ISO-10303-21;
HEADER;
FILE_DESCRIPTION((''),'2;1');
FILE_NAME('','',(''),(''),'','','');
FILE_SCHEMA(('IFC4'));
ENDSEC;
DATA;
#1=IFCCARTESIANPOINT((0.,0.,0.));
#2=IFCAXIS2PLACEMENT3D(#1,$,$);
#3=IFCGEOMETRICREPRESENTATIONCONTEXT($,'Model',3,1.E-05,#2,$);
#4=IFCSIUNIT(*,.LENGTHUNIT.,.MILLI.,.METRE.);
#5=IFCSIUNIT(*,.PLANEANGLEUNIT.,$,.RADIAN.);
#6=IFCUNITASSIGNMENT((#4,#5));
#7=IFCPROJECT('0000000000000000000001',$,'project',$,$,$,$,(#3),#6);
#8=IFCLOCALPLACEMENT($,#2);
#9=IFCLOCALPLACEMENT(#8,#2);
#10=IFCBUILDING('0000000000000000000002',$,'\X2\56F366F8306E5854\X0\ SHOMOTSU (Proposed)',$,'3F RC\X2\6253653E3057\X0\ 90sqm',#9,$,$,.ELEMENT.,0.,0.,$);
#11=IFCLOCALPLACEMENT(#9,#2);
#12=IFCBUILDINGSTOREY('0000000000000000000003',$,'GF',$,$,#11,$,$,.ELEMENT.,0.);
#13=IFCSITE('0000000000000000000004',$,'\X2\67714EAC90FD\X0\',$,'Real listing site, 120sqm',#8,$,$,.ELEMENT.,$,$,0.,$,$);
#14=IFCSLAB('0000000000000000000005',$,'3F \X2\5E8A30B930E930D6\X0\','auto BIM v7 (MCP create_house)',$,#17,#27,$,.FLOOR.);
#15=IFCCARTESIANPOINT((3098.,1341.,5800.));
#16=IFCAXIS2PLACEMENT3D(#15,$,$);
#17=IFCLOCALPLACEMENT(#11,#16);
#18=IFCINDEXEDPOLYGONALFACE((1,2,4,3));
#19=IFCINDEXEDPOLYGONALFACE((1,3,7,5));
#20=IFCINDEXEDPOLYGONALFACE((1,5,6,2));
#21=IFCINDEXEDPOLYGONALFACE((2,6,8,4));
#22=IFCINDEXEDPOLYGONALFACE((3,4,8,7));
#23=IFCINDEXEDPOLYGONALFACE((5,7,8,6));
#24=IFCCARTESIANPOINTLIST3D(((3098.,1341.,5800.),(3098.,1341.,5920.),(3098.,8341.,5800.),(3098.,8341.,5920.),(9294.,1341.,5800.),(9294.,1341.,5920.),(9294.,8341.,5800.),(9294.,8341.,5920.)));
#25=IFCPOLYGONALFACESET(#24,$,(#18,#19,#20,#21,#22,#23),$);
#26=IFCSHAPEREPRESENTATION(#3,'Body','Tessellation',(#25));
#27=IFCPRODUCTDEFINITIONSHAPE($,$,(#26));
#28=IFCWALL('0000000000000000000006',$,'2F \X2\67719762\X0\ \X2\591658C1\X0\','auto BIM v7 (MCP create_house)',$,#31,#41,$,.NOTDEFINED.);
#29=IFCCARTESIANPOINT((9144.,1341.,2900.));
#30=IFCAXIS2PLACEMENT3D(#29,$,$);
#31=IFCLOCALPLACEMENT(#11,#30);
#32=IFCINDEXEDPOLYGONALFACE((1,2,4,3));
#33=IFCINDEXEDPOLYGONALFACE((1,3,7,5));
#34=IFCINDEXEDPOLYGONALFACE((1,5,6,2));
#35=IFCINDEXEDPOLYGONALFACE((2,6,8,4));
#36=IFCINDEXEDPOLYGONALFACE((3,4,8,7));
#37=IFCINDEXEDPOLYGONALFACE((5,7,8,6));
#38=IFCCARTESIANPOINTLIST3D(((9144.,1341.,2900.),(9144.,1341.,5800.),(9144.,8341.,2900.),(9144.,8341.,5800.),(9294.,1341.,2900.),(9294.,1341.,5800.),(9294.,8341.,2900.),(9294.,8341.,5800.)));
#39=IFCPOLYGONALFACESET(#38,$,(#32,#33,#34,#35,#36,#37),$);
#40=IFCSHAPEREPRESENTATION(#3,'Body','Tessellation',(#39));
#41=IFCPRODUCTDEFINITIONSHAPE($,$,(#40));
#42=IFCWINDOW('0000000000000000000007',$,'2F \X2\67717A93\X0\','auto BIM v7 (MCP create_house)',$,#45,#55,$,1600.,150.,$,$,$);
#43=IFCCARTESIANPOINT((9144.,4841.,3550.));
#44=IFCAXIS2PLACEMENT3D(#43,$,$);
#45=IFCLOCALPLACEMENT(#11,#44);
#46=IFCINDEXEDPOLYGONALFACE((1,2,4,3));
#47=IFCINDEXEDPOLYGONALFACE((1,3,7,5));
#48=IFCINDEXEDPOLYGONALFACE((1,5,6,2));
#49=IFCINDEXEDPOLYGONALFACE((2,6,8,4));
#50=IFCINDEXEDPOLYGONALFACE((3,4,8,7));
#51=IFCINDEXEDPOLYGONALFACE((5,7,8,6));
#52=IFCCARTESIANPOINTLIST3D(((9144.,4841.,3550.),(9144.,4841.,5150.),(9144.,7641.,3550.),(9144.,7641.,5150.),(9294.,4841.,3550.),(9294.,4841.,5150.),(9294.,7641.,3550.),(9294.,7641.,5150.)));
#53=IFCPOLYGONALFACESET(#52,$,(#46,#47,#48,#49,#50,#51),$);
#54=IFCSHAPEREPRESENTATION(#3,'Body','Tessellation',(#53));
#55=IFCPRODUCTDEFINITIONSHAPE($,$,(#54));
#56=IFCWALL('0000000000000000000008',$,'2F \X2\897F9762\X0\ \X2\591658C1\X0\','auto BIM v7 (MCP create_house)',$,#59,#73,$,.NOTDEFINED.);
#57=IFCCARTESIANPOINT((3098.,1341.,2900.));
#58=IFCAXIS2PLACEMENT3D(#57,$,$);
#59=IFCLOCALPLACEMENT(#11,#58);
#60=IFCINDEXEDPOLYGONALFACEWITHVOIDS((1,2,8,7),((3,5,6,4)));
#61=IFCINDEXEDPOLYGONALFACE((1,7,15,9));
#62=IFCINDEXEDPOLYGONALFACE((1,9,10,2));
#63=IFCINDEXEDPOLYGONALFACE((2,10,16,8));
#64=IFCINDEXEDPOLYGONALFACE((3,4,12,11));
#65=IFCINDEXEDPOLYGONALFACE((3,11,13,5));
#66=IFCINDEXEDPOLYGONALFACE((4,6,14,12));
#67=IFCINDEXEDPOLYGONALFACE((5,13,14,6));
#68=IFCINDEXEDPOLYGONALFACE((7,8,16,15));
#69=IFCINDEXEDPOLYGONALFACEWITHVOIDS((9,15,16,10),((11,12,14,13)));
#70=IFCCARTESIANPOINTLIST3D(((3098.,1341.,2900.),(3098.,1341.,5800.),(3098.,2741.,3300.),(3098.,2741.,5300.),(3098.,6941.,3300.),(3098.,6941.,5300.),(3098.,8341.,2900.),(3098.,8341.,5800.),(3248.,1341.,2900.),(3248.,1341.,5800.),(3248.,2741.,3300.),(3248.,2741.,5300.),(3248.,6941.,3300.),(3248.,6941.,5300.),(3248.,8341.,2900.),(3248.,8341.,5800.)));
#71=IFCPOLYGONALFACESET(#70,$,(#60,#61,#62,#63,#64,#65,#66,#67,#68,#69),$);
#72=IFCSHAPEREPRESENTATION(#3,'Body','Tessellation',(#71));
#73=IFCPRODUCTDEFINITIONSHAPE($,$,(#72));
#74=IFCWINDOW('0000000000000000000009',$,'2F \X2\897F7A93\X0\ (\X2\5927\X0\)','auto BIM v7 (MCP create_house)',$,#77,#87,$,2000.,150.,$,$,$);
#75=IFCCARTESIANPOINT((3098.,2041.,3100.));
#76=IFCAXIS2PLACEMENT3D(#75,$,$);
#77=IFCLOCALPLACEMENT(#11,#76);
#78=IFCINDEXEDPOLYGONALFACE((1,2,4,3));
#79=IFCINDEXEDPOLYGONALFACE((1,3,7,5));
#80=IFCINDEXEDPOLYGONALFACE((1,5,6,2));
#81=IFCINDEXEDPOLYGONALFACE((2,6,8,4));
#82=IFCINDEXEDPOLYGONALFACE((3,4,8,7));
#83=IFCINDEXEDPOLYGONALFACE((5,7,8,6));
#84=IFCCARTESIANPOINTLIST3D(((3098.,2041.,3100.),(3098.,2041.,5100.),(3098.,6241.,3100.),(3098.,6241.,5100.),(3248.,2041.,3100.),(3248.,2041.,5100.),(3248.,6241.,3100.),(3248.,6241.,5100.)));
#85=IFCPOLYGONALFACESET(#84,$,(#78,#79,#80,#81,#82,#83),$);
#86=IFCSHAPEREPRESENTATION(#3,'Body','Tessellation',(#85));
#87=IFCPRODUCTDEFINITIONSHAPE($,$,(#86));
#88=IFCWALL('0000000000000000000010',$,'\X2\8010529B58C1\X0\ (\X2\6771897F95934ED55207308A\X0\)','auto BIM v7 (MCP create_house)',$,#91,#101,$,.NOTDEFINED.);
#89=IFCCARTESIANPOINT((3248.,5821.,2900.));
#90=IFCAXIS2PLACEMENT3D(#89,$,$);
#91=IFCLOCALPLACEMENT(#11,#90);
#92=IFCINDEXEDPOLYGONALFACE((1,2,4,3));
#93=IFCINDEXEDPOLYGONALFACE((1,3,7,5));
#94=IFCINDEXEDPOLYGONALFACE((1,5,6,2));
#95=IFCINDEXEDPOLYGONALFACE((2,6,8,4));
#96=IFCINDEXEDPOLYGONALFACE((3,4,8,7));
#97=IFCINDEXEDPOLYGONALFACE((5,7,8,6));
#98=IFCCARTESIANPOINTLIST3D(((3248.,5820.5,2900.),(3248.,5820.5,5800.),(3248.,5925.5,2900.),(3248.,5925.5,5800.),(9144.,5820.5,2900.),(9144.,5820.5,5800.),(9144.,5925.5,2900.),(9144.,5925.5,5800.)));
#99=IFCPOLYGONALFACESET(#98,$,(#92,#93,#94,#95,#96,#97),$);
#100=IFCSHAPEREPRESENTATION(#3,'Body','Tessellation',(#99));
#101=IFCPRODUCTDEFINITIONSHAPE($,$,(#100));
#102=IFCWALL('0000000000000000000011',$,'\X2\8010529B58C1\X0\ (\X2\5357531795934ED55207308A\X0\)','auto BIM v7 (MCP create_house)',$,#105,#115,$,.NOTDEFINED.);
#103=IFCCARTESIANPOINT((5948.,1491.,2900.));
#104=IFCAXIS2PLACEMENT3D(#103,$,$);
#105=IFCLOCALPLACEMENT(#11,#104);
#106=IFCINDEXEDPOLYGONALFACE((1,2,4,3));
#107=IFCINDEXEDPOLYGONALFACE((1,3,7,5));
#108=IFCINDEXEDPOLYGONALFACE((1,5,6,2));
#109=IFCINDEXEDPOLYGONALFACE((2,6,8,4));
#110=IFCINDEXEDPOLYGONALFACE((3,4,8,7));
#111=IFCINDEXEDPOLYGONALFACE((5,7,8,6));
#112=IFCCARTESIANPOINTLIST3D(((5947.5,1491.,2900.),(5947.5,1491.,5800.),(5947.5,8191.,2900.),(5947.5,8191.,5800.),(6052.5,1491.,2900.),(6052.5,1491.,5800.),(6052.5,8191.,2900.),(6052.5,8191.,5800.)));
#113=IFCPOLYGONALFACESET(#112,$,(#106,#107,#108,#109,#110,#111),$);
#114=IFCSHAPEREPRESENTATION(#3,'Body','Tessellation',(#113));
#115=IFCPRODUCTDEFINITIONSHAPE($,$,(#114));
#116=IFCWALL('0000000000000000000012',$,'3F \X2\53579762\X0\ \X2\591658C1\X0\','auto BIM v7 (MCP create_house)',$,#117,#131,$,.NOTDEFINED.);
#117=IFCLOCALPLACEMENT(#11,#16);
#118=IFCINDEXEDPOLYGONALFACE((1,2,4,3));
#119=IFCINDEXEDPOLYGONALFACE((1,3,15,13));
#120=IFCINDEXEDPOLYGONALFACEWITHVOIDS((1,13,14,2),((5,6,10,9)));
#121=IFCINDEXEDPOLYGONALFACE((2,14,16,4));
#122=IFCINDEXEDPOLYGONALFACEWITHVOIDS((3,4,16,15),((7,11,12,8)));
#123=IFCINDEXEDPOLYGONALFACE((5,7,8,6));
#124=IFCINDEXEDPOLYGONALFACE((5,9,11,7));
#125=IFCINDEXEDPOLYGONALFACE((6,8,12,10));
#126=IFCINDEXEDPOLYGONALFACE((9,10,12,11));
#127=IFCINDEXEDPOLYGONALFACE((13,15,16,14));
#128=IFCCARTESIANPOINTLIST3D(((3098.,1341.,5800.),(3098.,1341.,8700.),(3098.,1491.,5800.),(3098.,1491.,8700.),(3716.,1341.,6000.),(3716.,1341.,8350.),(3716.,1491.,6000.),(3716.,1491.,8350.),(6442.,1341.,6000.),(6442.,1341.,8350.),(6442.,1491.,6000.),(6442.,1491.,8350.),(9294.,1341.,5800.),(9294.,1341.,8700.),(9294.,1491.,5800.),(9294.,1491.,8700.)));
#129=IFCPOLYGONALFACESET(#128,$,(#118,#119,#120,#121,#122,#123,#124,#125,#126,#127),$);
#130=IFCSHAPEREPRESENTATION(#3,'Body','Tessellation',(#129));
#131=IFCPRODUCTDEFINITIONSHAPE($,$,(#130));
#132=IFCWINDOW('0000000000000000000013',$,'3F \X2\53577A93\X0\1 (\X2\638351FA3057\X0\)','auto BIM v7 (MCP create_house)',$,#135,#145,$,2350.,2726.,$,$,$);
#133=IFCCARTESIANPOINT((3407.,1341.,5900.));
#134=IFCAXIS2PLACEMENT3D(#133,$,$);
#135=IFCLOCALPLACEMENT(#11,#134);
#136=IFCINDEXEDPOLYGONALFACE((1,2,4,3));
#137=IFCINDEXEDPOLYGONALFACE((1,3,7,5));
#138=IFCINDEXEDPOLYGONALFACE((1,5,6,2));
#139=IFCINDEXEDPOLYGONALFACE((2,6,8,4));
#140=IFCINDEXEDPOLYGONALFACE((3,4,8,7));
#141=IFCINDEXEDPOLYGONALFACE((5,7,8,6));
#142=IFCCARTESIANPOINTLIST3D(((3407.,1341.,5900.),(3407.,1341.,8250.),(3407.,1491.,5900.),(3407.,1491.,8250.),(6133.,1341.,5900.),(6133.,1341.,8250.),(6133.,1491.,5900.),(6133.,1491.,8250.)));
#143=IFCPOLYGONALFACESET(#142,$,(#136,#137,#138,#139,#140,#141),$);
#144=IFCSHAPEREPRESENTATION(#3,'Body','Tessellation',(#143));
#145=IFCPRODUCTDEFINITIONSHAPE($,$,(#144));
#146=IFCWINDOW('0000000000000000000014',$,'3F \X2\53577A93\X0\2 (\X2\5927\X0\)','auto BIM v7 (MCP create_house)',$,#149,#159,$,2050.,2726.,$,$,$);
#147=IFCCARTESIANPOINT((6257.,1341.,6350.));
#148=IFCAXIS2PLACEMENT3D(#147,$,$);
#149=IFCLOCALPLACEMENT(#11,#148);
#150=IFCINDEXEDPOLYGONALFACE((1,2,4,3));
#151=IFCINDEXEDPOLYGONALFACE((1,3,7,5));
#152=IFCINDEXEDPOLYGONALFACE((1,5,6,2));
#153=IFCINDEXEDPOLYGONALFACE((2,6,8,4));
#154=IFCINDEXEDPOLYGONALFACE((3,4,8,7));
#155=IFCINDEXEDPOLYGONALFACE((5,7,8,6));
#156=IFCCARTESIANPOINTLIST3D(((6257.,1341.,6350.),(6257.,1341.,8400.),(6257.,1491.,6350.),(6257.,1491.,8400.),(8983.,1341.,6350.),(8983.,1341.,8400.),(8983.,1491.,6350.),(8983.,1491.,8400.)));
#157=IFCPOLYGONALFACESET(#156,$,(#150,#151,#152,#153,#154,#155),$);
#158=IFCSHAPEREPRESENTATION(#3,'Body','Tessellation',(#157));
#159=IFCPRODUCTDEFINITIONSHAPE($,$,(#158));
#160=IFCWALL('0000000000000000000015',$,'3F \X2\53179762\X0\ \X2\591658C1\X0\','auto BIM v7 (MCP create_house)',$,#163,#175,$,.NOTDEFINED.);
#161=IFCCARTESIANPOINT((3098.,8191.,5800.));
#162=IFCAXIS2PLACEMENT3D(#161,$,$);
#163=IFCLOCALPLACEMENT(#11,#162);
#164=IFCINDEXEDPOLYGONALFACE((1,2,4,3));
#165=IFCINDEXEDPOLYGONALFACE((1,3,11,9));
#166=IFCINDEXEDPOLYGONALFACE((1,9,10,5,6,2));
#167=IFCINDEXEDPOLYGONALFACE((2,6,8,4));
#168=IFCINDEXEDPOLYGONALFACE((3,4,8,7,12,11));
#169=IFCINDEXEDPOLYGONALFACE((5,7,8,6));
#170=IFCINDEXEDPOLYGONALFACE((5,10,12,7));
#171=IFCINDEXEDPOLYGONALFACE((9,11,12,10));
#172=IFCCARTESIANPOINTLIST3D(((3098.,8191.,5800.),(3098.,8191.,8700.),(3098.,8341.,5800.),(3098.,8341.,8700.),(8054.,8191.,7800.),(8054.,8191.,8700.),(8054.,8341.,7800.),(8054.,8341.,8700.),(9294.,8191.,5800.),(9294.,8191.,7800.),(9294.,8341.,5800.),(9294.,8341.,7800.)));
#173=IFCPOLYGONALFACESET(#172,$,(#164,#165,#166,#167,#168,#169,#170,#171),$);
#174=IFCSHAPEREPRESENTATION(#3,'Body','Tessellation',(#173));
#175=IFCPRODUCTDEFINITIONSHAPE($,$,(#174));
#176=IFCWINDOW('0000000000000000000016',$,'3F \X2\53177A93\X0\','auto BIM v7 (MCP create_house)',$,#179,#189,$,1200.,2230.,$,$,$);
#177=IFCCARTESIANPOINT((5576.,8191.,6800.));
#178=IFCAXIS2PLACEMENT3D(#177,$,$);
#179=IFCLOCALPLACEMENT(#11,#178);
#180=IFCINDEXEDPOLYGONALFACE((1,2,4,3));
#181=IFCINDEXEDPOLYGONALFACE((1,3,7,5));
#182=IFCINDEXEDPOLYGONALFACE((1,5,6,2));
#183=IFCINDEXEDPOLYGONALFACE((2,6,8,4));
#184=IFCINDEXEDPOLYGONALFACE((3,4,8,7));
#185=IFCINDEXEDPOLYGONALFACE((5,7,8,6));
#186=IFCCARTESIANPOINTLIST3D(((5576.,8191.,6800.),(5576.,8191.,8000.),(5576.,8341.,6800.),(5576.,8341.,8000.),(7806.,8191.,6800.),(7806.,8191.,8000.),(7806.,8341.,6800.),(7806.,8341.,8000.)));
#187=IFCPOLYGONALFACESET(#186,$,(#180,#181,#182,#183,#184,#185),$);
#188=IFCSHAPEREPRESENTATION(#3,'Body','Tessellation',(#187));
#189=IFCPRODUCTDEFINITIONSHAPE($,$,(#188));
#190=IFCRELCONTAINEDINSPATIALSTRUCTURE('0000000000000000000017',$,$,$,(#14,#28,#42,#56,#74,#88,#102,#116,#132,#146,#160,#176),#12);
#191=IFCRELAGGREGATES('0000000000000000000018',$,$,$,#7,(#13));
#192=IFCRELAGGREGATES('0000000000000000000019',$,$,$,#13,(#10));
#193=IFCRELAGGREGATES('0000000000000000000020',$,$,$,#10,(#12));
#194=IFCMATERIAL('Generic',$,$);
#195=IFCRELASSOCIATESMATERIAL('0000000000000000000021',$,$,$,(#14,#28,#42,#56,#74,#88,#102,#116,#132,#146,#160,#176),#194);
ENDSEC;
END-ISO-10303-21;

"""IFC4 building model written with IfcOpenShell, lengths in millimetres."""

from ifc_helpers import new_model, si_unit, frame, frame_2d, origin, place, context, project, spatial, rectangle, extrude, material, element, fill, save


model = new_model("IFC4")

# Units and contexts
model_context = context("Model", 3, precision=1e-05, world=origin())
ifc_project = project(units=[si_unit("LENGTHUNIT", "METRE", prefix="MILLI"), si_unit("PLANEANGLEUNIT", "RADIAN")], contexts=[model_context])

# Site, building, storey
site_placement = place(None, origin())
site = spatial("IfcSite", under=ifc_project, at=site_placement, Name="東京都", ObjectType="Real listing site, 120sqm", CompositionType="ELEMENT", RefElevation=0.0)
building_placement = place(site_placement, origin())
building = spatial("IfcBuilding", under=site, at=building_placement, Name="図書の塔 SHOMOTSU (Proposed)", ObjectType="3F RC打放し 90sqm", CompositionType="ELEMENT", ElevationOfRefHeight=0.0, ElevationOfTerrain=0.0)
storey_placement = place(building_placement, origin())
storey = spatial("IfcBuildingStorey", under=building, at=storey_placement, Name="GF", CompositionType="ELEMENT", Elevation=0.0)

# Slab
ifc_material = material(Name="Generic")
slab_placement = place(storey_placement, frame((3098.0, 1341.0, 5800.0)))
element("IfcSlab", 1, at=slab_placement, inside=storey, material=ifc_material, Name="3F 床スラブ", Description="auto BIM v7 (MCP create_house)", PredefinedType="FLOOR", context=model_context, shape_type="SweptSolid", body=[
    extrude(rectangle(XDim=6196.0, YDim=7000.0, at=frame_2d((3098.0, 3500.0))), frame((3098.0, 1341.0, 5800.0)), (0.0, 0.0, 1.0), 120.0),
])

# Walls, openings, windows
wall_1_placement = place(storey_placement, frame((9144.0, 1341.0, 2900.0)))
wall_1 = element("IfcWall", 2, at=wall_1_placement, inside=storey, material=ifc_material, Name="2F 東面 外壁", Description="auto BIM v7 (MCP create_house)", PredefinedType="NOTDEFINED", context=model_context, shape_type="SweptSolid", body=[
    extrude(rectangle(XDim=150.0, YDim=7000.0, at=frame_2d((75.0, 3500.0))), frame((9144.0, 1341.0, 2900.0)), (0.0, 0.0, 1.0), 2900.0),
])
opening_1_placement = place(storey_placement, frame((9144.0, 4841.0, 3550.0)))
opening_1 = element("IfcOpeningElement", 3, at=opening_1_placement, cuts=wall_1, PredefinedType="NOTDEFINED", context=model_context, shape_type="SweptSolid", body=[
    extrude(rectangle(XDim=150.0, YDim=2800.0, at=frame_2d((75.0, 1400.0))), frame((9144.0, 4841.0, 3550.0)), (0.0, 0.0, 1.0), 1600.0),
])
window_1_placement = place(storey_placement, frame((9144.0, 4841.0, 3550.0)))
window_1 = element("IfcWindow", 4, at=window_1_placement, inside=storey, material=ifc_material, Name="2F 東窓", Description="auto BIM v7 (MCP create_house)", OverallHeight=1600.0, OverallWidth=150.0, context=model_context, shape_type="SweptSolid", body=[
    extrude(rectangle(XDim=150.0, YDim=2800.0, at=frame_2d((75.0, 1400.0))), frame((9144.0, 4841.0, 3550.0)), (0.0, 0.0, 1.0), 1600.0),
])
fill(opening_1, window_1)
wall_2_placement = place(storey_placement, frame((3098.0, 1341.0, 2900.0)))
wall_2 = element("IfcWall", 5, at=wall_2_placement, inside=storey, material=ifc_material, Name="2F 西面 外壁", Description="auto BIM v7 (MCP create_house)", PredefinedType="NOTDEFINED", context=model_context, shape_type="SweptSolid", body=[
    extrude(rectangle(XDim=150.0, YDim=7000.0, at=frame_2d((75.0, 3500.0))), frame((3098.0, 1341.0, 2900.0)), (0.0, 0.0, 1.0), 2900.0),
])
opening_2_placement = place(storey_placement, frame((3098.0, 2041.0, 3100.0)))
opening_2 = element("IfcOpeningElement", 6, at=opening_2_placement, cuts=wall_2, PredefinedType="NOTDEFINED", context=model_context, shape_type="SweptSolid", body=[
    extrude(rectangle(XDim=150.0, YDim=4200.0, at=frame_2d((75.0, 2100.0))), frame((3098.0, 2041.0, 3100.0)), (0.0, 0.0, 1.0), 2000.0),
])
window_2_placement = place(storey_placement, frame((3098.0, 2041.0, 3100.0)))
window_2 = element("IfcWindow", 7, at=window_2_placement, inside=storey, material=ifc_material, Name="2F 西窓 (大)", Description="auto BIM v7 (MCP create_house)", OverallHeight=2000.0, OverallWidth=150.0, context=model_context, shape_type="SweptSolid", body=[
    extrude(rectangle(XDim=150.0, YDim=4200.0, at=frame_2d((75.0, 2100.0))), frame((3098.0, 2041.0, 3100.0)), (0.0, 0.0, 1.0), 2000.0),
])
fill(opening_2, window_2)

# Walls
wall_3_placement = place(storey_placement, frame((3248.0, 5821.0, 2900.0)))
element("IfcWall", 8, at=wall_3_placement, inside=storey, material=ifc_material, Name="耐力壁 (東西間仕切り)", Description="auto BIM v7 (MCP create_house)", PredefinedType="NOTDEFINED", context=model_context, shape_type="SweptSolid", body=[
    extrude(rectangle(XDim=5896.0, YDim=105.0, at=frame_2d((2948.0, 52.0))), frame((3248.0, 5821.0, 2900.0)), (0.0, 0.0, 1.0), 2900.0),
])
wall_4_placement = place(storey_placement, frame((5948.0, 1491.0, 2900.0)))
element("IfcWall", 9, at=wall_4_placement, inside=storey, material=ifc_material, Name="耐力壁 (南北間仕切り)", Description="auto BIM v7 (MCP create_house)", PredefinedType="NOTDEFINED", context=model_context, shape_type="SweptSolid", body=[
    extrude(rectangle(XDim=105.0, YDim=6700.0, at=frame_2d((52.0, 3350.0))), frame((5948.0, 1491.0, 2900.0)), (0.0, 0.0, 1.0), 2900.0),
])

# Wall, openings, windows
wall_5_placement = place(storey_placement, frame((3098.0, 1341.0, 5800.0)))
wall_5 = element("IfcWall", 10, at=wall_5_placement, inside=storey, material=ifc_material, Name="3F 南面 外壁", Description="auto BIM v7 (MCP create_house)", PredefinedType="NOTDEFINED", context=model_context, shape_type="SweptSolid", body=[
    extrude(rectangle(XDim=6196.0, YDim=150.0, at=frame_2d((3098.0, 75.0))), frame((3098.0, 1341.0, 5800.0)), (0.0, 0.0, 1.0), 2900.0),
])
opening_3_placement = place(storey_placement, frame((3407.0, 1341.0, 5900.0)))
opening_3 = element("IfcOpeningElement", 11, at=opening_3_placement, cuts=wall_5, PredefinedType="NOTDEFINED", context=model_context, shape_type="SweptSolid", body=[
    extrude(rectangle(XDim=2726.0, YDim=150.0, at=frame_2d((1363.0, 75.0))), frame((3407.0, 1341.0, 5900.0)), (0.0, 0.0, 1.0), 2350.0),
])
opening_4_placement = place(storey_placement, frame((6257.0, 1341.0, 6350.0)))
opening_4 = element("IfcOpeningElement", 12, at=opening_4_placement, cuts=wall_5, PredefinedType="NOTDEFINED", context=model_context, shape_type="SweptSolid", body=[
    extrude(rectangle(XDim=2726.0, YDim=150.0, at=frame_2d((1363.0, 75.0))), frame((6257.0, 1341.0, 6350.0)), (0.0, 0.0, 1.0), 2050.0),
])
window_3_placement = place(storey_placement, frame((3407.0, 1341.0, 5900.0)))
window_3 = element("IfcWindow", 13, at=window_3_placement, inside=storey, material=ifc_material, Name="3F 南窓1 (掃出し)", Description="auto BIM v7 (MCP create_house)", OverallHeight=2350.0, OverallWidth=2726.0, context=model_context, shape_type="SweptSolid", body=[
    extrude(rectangle(XDim=2726.0, YDim=150.0, at=frame_2d((1363.0, 75.0))), frame((3407.0, 1341.0, 5900.0)), (0.0, 0.0, 1.0), 2350.0),
])
fill(opening_3, window_3)
window_4_placement = place(storey_placement, frame((6257.0, 1341.0, 6350.0)))
window_4 = element("IfcWindow", 14, at=window_4_placement, inside=storey, material=ifc_material, Name="3F 南窓2 (大)", Description="auto BIM v7 (MCP create_house)", OverallHeight=2050.0, OverallWidth=2726.0, context=model_context, shape_type="SweptSolid", body=[
    extrude(rectangle(XDim=2726.0, YDim=150.0, at=frame_2d((1363.0, 75.0))), frame((6257.0, 1341.0, 6350.0)), (0.0, 0.0, 1.0), 2050.0),
])
fill(opening_4, window_4)

# Wall, opening, window
wall_6_placement = place(storey_placement, frame((3098.0, 8191.0, 5800.0)))
wall_6 = element("IfcWall", 15, at=wall_6_placement, inside=storey, material=ifc_material, Name="3F 北面 外壁", Description="auto BIM v7 (MCP create_house)", PredefinedType="NOTDEFINED", context=model_context, shape_type="SweptSolid", body=[
    extrude(rectangle(XDim=6196.0, YDim=150.0, at=frame_2d((3098.0, 75.0))), frame((3098.0, 8191.0, 5800.0)), (0.0, 0.0, 1.0), 2900.0),
])
opening_5_placement = place(storey_placement, frame((5576.0, 8191.0, 6800.0)))
opening_5 = element("IfcOpeningElement", 16, at=opening_5_placement, cuts=wall_6, PredefinedType="NOTDEFINED", context=model_context, shape_type="SweptSolid", body=[
    extrude(rectangle(XDim=2230.0, YDim=150.0, at=frame_2d((1115.0, 75.0))), frame((5576.0, 8191.0, 6800.0)), (0.0, 0.0, 1.0), 1200.0),
])
window_5_placement = place(storey_placement, frame((5576.0, 8191.0, 6800.0)))
window_5 = element("IfcWindow", 17, at=window_5_placement, inside=storey, material=ifc_material, Name="3F 北窓", Description="auto BIM v7 (MCP create_house)", OverallHeight=1200.0, OverallWidth=2230.0, context=model_context, shape_type="SweptSolid", body=[
    extrude(rectangle(XDim=2230.0, YDim=150.0, at=frame_2d((1115.0, 75.0))), frame((5576.0, 8191.0, 6800.0)), (0.0, 0.0, 1.0), 1200.0),
])
fill(opening_5, window_5)

save(model, "model.ifc")
